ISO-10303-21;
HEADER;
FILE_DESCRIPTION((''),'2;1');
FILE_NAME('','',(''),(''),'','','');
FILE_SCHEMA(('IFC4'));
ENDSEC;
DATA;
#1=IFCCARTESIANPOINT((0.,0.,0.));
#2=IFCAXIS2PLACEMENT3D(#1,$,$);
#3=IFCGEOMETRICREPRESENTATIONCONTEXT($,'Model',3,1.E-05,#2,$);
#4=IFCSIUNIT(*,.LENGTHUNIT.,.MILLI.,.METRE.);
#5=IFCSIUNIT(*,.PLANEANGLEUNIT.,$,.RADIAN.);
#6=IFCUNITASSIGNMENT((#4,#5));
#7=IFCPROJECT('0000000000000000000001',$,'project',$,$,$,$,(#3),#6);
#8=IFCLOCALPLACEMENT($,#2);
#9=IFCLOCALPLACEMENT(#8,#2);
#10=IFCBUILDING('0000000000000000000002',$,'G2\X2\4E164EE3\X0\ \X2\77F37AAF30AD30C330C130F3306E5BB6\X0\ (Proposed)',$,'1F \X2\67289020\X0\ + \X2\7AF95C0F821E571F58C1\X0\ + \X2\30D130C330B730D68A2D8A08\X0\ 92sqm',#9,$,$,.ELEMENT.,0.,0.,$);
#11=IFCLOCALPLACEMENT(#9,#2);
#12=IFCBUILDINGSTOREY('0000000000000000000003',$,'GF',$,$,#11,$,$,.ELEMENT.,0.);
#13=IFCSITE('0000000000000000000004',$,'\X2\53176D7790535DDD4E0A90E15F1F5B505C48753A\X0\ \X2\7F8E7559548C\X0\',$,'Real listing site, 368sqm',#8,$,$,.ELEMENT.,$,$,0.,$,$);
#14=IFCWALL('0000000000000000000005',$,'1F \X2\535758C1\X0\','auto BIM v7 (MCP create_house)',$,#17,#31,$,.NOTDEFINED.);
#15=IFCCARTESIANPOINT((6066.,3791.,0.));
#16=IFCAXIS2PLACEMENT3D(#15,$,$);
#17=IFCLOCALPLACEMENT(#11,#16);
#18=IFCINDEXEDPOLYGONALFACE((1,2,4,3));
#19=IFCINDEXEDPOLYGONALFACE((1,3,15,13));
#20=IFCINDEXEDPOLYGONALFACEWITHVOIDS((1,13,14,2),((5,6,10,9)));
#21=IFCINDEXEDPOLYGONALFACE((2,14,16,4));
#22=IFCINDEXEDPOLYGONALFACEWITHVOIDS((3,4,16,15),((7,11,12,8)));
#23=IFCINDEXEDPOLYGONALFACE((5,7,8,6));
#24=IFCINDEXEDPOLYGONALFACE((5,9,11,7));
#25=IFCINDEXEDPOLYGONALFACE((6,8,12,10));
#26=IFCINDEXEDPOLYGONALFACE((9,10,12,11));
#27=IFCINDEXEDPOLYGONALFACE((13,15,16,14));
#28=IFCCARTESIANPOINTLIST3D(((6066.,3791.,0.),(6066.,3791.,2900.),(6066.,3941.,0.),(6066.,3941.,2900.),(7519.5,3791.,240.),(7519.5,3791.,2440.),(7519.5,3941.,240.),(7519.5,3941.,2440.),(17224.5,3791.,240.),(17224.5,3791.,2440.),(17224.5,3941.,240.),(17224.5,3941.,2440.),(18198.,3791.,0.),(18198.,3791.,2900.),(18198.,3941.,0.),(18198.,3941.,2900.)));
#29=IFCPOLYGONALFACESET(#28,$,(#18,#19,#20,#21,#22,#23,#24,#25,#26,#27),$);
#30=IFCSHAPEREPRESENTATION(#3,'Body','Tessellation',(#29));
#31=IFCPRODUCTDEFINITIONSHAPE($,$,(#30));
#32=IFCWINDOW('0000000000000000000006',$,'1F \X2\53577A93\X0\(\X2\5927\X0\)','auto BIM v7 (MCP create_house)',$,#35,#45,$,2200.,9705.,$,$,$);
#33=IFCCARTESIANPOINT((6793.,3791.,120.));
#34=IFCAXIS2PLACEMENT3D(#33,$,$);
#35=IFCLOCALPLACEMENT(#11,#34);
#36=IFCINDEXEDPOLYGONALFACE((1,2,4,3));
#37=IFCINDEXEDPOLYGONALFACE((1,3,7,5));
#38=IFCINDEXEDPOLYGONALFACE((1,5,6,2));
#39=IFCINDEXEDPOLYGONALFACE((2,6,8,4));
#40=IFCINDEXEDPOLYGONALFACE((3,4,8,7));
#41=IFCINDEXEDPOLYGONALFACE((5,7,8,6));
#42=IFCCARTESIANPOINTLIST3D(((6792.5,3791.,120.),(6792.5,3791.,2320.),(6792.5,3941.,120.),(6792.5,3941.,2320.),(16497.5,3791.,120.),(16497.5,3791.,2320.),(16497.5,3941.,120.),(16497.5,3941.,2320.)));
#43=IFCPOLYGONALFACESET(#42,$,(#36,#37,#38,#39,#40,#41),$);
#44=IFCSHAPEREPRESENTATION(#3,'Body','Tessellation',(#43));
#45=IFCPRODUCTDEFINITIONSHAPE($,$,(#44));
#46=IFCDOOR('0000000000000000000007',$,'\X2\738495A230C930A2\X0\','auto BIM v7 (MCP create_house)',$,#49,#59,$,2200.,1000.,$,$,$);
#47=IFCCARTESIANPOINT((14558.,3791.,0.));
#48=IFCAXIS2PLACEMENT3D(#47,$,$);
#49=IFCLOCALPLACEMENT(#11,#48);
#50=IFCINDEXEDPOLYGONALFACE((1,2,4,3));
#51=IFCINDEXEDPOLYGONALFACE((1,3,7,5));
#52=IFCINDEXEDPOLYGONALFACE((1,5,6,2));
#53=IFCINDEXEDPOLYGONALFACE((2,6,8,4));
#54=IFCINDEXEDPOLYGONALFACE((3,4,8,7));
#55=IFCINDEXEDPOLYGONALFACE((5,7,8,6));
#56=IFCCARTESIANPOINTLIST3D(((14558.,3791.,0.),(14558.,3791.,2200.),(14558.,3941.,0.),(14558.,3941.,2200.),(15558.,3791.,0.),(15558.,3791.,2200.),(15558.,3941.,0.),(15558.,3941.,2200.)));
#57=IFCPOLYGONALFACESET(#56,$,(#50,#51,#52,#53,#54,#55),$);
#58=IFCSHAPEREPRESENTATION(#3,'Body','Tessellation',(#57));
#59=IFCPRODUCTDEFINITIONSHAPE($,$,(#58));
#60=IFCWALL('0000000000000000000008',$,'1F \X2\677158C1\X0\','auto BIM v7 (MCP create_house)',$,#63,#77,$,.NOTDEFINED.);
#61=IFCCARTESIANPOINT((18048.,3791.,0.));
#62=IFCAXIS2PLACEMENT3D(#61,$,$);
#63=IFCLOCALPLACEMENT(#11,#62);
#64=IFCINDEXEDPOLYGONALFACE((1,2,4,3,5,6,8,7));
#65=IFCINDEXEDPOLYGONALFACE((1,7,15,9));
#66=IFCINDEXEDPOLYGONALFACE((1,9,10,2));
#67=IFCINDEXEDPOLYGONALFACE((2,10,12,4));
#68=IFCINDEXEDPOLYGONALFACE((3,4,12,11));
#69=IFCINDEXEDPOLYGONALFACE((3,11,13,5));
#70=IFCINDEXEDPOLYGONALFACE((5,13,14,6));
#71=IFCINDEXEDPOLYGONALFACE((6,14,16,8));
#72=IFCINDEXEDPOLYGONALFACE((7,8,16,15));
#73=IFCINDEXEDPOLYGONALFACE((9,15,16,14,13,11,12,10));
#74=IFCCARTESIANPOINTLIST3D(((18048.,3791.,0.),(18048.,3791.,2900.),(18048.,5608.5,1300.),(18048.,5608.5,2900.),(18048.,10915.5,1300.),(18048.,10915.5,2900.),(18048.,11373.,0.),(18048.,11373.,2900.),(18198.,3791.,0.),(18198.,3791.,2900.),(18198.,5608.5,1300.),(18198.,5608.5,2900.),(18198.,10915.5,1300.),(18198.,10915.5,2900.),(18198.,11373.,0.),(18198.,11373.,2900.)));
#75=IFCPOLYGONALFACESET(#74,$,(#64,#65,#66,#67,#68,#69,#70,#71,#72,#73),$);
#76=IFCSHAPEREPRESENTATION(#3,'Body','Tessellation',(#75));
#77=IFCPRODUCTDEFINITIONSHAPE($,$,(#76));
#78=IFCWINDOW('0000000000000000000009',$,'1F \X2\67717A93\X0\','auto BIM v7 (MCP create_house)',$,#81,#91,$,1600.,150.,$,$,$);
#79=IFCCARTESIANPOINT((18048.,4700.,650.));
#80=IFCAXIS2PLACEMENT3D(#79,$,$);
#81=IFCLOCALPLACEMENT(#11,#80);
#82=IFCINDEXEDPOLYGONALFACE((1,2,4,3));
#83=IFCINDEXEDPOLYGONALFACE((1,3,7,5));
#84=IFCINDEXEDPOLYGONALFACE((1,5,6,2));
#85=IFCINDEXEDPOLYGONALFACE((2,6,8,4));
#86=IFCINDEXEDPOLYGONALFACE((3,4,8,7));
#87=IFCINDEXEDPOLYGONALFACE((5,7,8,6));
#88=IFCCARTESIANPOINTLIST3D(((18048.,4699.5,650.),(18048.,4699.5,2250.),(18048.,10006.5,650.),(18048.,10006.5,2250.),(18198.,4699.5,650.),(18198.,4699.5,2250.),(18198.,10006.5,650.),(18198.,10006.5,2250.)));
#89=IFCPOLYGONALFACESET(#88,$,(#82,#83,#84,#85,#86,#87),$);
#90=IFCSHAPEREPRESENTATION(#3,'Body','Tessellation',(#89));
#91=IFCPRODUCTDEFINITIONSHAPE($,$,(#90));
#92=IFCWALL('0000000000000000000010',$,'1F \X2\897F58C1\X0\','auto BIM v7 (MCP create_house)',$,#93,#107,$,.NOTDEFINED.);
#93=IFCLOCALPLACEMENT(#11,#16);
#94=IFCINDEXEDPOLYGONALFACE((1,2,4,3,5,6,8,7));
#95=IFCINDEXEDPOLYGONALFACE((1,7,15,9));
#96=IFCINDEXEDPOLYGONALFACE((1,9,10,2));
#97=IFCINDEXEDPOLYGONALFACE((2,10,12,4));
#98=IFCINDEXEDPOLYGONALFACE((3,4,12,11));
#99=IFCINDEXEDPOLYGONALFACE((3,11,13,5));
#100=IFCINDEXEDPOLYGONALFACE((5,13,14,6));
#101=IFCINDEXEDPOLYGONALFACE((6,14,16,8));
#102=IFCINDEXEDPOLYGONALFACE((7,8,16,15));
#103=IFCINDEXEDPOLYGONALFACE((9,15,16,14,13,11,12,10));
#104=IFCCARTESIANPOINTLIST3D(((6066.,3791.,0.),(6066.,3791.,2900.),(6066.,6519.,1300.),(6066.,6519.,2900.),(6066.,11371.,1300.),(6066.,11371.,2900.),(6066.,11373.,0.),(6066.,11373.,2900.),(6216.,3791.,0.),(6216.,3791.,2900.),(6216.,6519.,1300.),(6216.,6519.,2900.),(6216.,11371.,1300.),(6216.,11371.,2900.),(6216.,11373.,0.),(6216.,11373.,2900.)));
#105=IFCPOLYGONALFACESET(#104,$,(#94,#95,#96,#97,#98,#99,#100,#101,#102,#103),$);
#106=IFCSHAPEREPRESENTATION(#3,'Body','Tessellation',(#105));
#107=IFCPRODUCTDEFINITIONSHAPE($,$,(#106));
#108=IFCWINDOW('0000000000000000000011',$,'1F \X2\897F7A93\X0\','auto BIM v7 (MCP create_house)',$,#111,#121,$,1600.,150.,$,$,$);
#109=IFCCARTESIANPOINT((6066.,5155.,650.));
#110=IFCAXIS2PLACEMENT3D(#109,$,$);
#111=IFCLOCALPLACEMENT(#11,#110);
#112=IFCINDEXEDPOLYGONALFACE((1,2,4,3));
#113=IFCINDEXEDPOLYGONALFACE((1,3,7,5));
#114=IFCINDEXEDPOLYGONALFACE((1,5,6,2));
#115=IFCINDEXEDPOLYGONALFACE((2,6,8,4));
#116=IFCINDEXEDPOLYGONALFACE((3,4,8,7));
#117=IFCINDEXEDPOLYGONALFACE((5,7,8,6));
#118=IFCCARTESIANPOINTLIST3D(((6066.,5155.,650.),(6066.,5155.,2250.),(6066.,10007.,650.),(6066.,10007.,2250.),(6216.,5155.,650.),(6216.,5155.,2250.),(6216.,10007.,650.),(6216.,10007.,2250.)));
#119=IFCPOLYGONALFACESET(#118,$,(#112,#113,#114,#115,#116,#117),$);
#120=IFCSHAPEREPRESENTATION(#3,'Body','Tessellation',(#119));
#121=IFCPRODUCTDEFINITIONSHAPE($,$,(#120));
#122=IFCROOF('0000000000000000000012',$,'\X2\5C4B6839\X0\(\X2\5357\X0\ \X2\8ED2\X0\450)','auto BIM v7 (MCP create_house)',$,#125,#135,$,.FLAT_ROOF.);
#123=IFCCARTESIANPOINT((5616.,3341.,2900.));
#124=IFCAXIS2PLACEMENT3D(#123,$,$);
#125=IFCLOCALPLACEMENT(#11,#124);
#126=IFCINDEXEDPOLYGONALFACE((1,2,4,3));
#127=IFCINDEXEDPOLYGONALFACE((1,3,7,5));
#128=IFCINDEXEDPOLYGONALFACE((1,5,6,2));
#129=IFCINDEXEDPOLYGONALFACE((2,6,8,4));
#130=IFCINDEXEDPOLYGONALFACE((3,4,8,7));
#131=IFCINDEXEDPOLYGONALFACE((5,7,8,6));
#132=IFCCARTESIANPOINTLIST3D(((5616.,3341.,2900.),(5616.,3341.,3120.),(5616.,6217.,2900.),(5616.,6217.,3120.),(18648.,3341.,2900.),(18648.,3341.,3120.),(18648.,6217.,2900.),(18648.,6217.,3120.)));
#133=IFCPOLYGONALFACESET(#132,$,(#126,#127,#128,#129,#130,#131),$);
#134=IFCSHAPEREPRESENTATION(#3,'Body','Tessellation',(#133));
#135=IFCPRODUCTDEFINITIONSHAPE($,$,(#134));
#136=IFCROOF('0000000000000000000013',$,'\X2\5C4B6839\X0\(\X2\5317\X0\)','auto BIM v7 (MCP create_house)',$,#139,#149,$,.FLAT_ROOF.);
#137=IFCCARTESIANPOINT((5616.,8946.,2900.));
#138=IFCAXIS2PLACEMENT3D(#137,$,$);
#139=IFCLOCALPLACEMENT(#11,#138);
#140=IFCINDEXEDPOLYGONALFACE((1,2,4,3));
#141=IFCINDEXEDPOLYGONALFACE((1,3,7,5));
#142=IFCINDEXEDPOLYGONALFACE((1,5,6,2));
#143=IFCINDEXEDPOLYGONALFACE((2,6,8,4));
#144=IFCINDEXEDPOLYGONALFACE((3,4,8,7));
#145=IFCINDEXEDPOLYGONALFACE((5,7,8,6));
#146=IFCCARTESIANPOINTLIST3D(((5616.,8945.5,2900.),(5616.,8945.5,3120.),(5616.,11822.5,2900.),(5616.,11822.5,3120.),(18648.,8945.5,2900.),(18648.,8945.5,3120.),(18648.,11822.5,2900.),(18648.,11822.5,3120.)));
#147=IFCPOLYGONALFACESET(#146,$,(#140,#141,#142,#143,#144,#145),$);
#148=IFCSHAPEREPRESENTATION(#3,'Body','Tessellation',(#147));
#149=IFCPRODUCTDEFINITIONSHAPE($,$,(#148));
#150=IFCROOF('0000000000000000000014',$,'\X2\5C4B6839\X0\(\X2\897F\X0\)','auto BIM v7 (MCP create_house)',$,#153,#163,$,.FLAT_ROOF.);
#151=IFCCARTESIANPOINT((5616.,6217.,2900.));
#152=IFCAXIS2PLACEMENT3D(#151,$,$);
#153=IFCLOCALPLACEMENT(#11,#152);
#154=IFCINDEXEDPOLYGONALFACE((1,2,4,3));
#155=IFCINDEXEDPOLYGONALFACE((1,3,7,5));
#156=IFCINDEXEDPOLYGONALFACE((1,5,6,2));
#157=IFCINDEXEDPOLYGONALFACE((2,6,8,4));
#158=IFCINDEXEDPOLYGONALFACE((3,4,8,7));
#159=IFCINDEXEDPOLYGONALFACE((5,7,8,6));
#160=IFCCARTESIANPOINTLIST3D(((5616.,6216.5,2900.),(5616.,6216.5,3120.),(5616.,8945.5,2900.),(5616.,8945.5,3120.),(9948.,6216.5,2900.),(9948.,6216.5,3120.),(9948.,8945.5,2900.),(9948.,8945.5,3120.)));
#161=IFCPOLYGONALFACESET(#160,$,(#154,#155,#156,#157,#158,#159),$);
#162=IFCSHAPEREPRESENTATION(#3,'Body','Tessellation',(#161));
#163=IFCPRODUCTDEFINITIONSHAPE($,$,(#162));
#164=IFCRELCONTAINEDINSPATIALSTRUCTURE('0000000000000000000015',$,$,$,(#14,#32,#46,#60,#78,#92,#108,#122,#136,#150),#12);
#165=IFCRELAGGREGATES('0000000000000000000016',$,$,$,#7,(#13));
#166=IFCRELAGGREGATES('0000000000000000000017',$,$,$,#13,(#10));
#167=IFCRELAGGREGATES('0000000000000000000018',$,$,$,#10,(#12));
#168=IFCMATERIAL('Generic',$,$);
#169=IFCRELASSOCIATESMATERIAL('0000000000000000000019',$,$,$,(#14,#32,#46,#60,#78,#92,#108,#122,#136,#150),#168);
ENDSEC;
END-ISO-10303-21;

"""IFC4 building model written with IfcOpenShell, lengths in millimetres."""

from ifc_helpers import new_model, si_unit, frame, frame_2d, origin, place, context, project, spatial, rectangle, extrude, material, element, fill, save


model = new_model("IFC4")

# Units and contexts
model_context = context("Model", 3, precision=1e-05, world=origin())
ifc_project = project(units=[si_unit("LENGTHUNIT", "METRE", prefix="MILLI"), si_unit("PLANEANGLEUNIT", "RADIAN")], contexts=[model_context])

# Site, building, storey
site_placement = place(None, origin())
site = spatial("IfcSite", under=ifc_project, at=site_placement, Name="北海道川上郡弟子屈町 美留和", ObjectType="Real listing site, 368sqm", CompositionType="ELEMENT", RefElevation=0.0)
building_placement = place(site_placement, origin())
building = spatial("IfcBuilding", under=site, at=building_placement, Name="G2世代 石窯キッチンの家 (Proposed)", ObjectType="1F 木造 + 竹小舞土壁 + パッシブ設計 92sqm", CompositionType="ELEMENT", ElevationOfRefHeight=0.0, ElevationOfTerrain=0.0)
storey_placement = place(building_placement, origin())
storey = spatial("IfcBuildingStorey", under=building, at=storey_placement, Name="GF", CompositionType="ELEMENT", Elevation=0.0)

# Shared definitions
ifc_material = material(Name="Generic")

# Wall, openings, window, door
wall_1_placement = place(storey_placement, frame((6066.0, 3791.0, 0.0)))
wall_1 = element("IfcWall", 1, at=wall_1_placement, inside=storey, material=ifc_material, Name="1F 南壁", Description="auto BIM v7 (MCP create_house)", PredefinedType="NOTDEFINED", context=model_context, shape_type="SweptSolid", body=[
    extrude(rectangle(XDim=12132.0, YDim=150.0, at=frame_2d((6066.0, 75.0))), frame((6066.0, 3791.0, 0.0)), (0.0, 0.0, 1.0), 2900.0),
])
opening_1_placement = place(storey_placement, frame((6793.0, 3791.0, 120.0)))
opening_1 = element("IfcOpeningElement", 2, at=opening_1_placement, cuts=wall_1, PredefinedType="NOTDEFINED", context=model_context, shape_type="SweptSolid", body=[
    extrude(rectangle(XDim=9705.0, YDim=150.0, at=frame_2d((4852.0, 75.0))), frame((6793.0, 3791.0, 120.0)), (0.0, 0.0, 1.0), 2200.0),
])
opening_2_placement = place(storey_placement, frame((14558.0, 3791.0, 0.0)))
opening_2 = element("IfcOpeningElement", 3, at=opening_2_placement, cuts=wall_1, PredefinedType="NOTDEFINED", context=model_context, shape_type="SweptSolid", body=[
    extrude(rectangle(XDim=1000.0, YDim=150.0, at=frame_2d((500.0, 75.0))), frame((14558.0, 3791.0, 0.0)), (0.0, 0.0, 1.0), 2200.0),
])
window_1_placement = place(storey_placement, frame((6793.0, 3791.0, 120.0)))
window_1 = element("IfcWindow", 4, at=window_1_placement, inside=storey, material=ifc_material, Name="1F 南窓(大)", Description="auto BIM v7 (MCP create_house)", OverallHeight=2200.0, OverallWidth=9705.0, context=model_context, shape_type="SweptSolid", body=[
    extrude(rectangle(XDim=9705.0, YDim=150.0, at=frame_2d((4852.0, 75.0))), frame((6793.0, 3791.0, 120.0)), (0.0, 0.0, 1.0), 2200.0),
])
fill(opening_1, window_1)
door_placement = place(storey_placement, frame((14558.0, 3791.0, 0.0)))
door = element("IfcDoor", 5, at=door_placement, inside=storey, material=ifc_material, Name="玄関ドア", Description="auto BIM v7 (MCP create_house)", OverallHeight=2200.0, OverallWidth=1000.0, context=model_context, shape_type="SweptSolid", body=[
    extrude(rectangle(XDim=1000.0, YDim=150.0, at=frame_2d((500.0, 75.0))), frame((14558.0, 3791.0, 0.0)), (0.0, 0.0, 1.0), 2200.0),
])
fill(opening_2, door)

# Walls, openings, windows
wall_2_placement = place(storey_placement, frame((18048.0, 3791.0, 0.0)))
wall_2 = element("IfcWall", 6, at=wall_2_placement, inside=storey, material=ifc_material, Name="1F 東壁", Description="auto BIM v7 (MCP create_house)", PredefinedType="NOTDEFINED", context=model_context, shape_type="SweptSolid", body=[
    extrude(rectangle(XDim=150.0, YDim=7582.0, at=frame_2d((75.0, 3791.0))), frame((18048.0, 3791.0, 0.0)), (0.0, 0.0, 1.0), 2900.0),
])
opening_3_placement = place(storey_placement, frame((18048.0, 4700.0, 650.0)))
opening_3 = element("IfcOpeningElement", 7, at=opening_3_placement, cuts=wall_2, PredefinedType="NOTDEFINED", context=model_context, shape_type="SweptSolid", body=[
    extrude(rectangle(XDim=150.0, YDim=5307.0, at=frame_2d((75.0, 2653.0))), frame((18048.0, 4700.0, 650.0)), (0.0, 0.0, 1.0), 1600.0),
])
window_2_placement = place(storey_placement, frame((18048.0, 4700.0, 650.0)))
window_2 = element("IfcWindow", 8, at=window_2_placement, inside=storey, material=ifc_material, Name="1F 東窓", Description="auto BIM v7 (MCP create_house)", OverallHeight=1600.0, OverallWidth=150.0, context=model_context, shape_type="SweptSolid", body=[
    extrude(rectangle(XDim=150.0, YDim=5307.0, at=frame_2d((75.0, 2653.0))), frame((18048.0, 4700.0, 650.0)), (0.0, 0.0, 1.0), 1600.0),
])
fill(opening_3, window_2)
wall_3_placement = place(storey_placement, frame((6066.0, 3791.0, 0.0)))
wall_3 = element("IfcWall", 9, at=wall_3_placement, inside=storey, material=ifc_material, Name="1F 西壁", Description="auto BIM v7 (MCP create_house)", PredefinedType="NOTDEFINED", context=model_context, shape_type="SweptSolid", body=[
    extrude(rectangle(XDim=150.0, YDim=7582.0, at=frame_2d((75.0, 3791.0))), frame((6066.0, 3791.0, 0.0)), (0.0, 0.0, 1.0), 2900.0),
])
opening_4_placement = place(storey_placement, frame((6066.0, 5155.0, 650.0)))
opening_4 = element("IfcOpeningElement", 10, at=opening_4_placement, cuts=wall_3, PredefinedType="NOTDEFINED", context=model_context, shape_type="SweptSolid", body=[
    extrude(rectangle(XDim=150.0, YDim=4852.0, at=frame_2d((75.0, 2426.0))), frame((6066.0, 5155.0, 650.0)), (0.0, 0.0, 1.0), 1600.0),
])
window_3_placement = place(storey_placement, frame((6066.0, 5155.0, 650.0)))
window_3 = element("IfcWindow", 11, at=window_3_placement, inside=storey, material=ifc_material, Name="1F 西窓", Description="auto BIM v7 (MCP create_house)", OverallHeight=1600.0, OverallWidth=150.0, context=model_context, shape_type="SweptSolid", body=[
    extrude(rectangle(XDim=150.0, YDim=4852.0, at=frame_2d((75.0, 2426.0))), frame((6066.0, 5155.0, 650.0)), (0.0, 0.0, 1.0), 1600.0),
])
fill(opening_4, window_3)

# Roofs
roof_1_placement = place(storey_placement, frame((5616.0, 3341.0, 2900.0)))
element("IfcRoof", 12, at=roof_1_placement, inside=storey, material=ifc_material, Name="屋根(南 軒450)", Description="auto BIM v7 (MCP create_house)", PredefinedType="FLAT_ROOF", context=model_context, shape_type="SweptSolid", body=[
    extrude(rectangle(XDim=13032.0, YDim=2876.0, at=frame_2d((6516.0, 1438.0))), frame((5616.0, 3341.0, 2900.0)), (0.0, 0.0, 1.0), 220.0),
])
roof_2_placement = place(storey_placement, frame((5616.0, 8946.0, 2900.0)))
element("IfcRoof", 13, at=roof_2_placement, inside=storey, material=ifc_material, Name="屋根(北)", Description="auto BIM v7 (MCP create_house)", PredefinedType="FLAT_ROOF", context=model_context, shape_type="SweptSolid", body=[
    extrude(rectangle(XDim=13032.0, YDim=2877.0, at=frame_2d((6516.0, 1438.0))), frame((5616.0, 8946.0, 2900.0)), (0.0, 0.0, 1.0), 220.0),
])
roof_3_placement = place(storey_placement, frame((5616.0, 6217.0, 2900.0)))
element("IfcRoof", 14, at=roof_3_placement, inside=storey, material=ifc_material, Name="屋根(西)", Description="auto BIM v7 (MCP create_house)", PredefinedType="FLAT_ROOF", context=model_context, shape_type="SweptSolid", body=[
    extrude(rectangle(XDim=4332.0, YDim=2729.0, at=frame_2d((2166.0, 1364.0))), frame((5616.0, 6217.0, 2900.0)), (0.0, 0.0, 1.0), 220.0),
])

save(model, "model.ifc")
